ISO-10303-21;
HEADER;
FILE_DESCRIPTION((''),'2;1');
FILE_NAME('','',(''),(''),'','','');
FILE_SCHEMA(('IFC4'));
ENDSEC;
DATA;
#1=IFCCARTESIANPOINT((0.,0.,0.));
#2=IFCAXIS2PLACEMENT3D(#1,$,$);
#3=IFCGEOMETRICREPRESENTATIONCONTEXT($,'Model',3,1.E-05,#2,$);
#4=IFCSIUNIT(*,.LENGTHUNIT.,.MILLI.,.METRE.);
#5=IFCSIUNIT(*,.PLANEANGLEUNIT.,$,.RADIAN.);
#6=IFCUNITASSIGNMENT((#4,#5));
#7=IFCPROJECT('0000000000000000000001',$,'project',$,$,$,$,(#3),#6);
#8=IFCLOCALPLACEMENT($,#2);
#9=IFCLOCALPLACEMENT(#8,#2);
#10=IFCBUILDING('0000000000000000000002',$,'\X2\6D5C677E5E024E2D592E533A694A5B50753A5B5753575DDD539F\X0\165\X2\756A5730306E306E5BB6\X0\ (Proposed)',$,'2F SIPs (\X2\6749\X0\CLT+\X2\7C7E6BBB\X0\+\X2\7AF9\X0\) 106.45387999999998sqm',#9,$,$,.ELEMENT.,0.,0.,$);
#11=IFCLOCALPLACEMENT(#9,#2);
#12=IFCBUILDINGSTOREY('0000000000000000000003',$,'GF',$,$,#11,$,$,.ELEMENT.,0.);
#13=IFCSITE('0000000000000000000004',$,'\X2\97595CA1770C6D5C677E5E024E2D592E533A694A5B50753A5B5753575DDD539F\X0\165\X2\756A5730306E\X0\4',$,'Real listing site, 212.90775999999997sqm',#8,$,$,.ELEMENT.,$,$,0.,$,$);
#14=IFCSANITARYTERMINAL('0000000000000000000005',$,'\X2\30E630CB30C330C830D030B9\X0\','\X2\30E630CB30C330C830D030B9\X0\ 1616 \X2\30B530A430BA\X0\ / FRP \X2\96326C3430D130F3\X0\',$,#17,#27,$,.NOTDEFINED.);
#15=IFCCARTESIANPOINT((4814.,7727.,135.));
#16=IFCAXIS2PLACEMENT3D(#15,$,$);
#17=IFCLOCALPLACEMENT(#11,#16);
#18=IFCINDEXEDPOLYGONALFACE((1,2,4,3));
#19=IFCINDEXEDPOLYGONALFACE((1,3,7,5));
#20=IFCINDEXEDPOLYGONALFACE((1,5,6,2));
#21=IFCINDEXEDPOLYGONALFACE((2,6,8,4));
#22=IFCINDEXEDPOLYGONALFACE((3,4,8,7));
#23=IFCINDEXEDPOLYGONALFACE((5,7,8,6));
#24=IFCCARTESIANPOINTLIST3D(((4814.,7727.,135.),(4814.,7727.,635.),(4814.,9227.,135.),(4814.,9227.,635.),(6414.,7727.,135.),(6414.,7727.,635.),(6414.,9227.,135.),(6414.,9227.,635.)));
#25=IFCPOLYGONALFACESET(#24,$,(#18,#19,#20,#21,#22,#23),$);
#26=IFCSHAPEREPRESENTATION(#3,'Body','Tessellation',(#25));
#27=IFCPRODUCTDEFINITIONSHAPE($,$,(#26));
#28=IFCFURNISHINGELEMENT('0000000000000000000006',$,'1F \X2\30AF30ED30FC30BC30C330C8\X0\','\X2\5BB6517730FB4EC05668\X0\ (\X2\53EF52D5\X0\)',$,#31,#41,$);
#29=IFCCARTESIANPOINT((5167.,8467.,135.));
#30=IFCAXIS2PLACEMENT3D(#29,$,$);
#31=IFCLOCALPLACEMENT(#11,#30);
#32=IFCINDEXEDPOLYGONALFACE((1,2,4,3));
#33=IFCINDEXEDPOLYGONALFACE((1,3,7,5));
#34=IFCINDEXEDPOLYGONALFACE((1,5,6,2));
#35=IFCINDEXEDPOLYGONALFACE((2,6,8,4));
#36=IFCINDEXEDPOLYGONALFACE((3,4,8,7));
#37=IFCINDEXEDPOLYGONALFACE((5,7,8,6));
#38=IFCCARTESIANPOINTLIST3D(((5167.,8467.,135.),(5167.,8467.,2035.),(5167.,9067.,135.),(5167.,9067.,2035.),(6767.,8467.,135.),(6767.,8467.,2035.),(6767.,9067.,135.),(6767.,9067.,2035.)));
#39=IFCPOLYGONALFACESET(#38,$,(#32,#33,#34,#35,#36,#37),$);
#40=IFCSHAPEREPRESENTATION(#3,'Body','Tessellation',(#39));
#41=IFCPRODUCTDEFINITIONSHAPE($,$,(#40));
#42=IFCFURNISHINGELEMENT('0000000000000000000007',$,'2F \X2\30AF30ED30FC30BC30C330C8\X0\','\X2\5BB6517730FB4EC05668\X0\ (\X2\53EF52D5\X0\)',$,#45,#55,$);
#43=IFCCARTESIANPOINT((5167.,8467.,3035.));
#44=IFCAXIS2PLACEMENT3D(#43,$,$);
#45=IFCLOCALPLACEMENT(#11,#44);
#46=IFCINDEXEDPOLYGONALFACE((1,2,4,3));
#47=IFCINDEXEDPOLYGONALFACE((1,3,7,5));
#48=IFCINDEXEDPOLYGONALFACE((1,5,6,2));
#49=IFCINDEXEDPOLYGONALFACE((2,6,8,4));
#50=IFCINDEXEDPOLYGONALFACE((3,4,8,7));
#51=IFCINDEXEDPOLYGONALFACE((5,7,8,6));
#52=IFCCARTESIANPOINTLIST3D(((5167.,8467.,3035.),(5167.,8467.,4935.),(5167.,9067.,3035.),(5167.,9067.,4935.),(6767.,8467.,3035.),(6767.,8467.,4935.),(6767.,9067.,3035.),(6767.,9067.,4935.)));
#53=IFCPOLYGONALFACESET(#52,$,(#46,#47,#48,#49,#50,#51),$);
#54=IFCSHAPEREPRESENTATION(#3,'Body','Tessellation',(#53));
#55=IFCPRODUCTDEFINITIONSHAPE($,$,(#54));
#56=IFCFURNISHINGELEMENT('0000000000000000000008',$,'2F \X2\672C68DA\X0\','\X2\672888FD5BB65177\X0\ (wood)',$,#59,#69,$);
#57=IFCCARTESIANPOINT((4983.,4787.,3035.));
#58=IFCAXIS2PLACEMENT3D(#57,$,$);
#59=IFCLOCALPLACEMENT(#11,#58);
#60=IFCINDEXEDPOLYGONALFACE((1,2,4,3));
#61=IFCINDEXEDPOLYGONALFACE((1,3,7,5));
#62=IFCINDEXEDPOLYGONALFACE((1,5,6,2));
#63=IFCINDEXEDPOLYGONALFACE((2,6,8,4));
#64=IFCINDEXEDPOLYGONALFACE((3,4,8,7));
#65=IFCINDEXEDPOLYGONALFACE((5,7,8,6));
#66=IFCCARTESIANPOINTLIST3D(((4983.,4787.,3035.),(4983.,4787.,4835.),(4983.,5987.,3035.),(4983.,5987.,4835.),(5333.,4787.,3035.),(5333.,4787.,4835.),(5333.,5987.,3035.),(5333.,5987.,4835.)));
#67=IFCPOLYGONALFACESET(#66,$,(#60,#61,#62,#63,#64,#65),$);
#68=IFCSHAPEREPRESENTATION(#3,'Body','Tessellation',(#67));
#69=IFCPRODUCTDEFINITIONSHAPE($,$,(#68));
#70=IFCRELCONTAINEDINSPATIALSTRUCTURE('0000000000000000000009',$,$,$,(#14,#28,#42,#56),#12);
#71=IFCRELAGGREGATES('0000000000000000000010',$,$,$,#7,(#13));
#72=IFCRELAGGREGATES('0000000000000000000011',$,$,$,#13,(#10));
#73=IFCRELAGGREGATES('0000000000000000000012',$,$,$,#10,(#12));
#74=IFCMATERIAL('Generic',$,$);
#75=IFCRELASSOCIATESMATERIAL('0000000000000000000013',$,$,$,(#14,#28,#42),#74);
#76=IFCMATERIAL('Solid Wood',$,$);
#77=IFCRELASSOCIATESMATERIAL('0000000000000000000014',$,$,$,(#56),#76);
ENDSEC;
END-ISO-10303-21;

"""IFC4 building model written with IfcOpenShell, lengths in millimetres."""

from ifc_helpers import new_model, si_unit, frame, frame_2d, origin, place, context, project, spatial, rectangle, extrude, material, element, save


model = new_model("IFC4")

# Units and contexts
model_context = context("Model", 3, precision=1e-05, world=origin())
ifc_project = project(units=[si_unit("LENGTHUNIT", "METRE", prefix="MILLI"), si_unit("PLANEANGLEUNIT", "RADIAN")], contexts=[model_context])

# Site, building, storey
site_placement = place(None, origin())
site = spatial("IfcSite", under=ifc_project, at=site_placement, Name="静岡県浜松市中央区楊子町字南川原165番地の4", ObjectType="Real listing site, 212.90775999999997sqm", CompositionType="ELEMENT", RefElevation=0.0)
building_placement = place(site_placement, origin())
building = spatial("IfcBuilding", under=site, at=building_placement, Name="浜松市中央区楊子町字南川原165番地のの家 (Proposed)", ObjectType="2F SIPs (杉CLT+籾殻+竹) 106.45387999999998sqm", CompositionType="ELEMENT", ElevationOfRefHeight=0.0, ElevationOfTerrain=0.0)
storey_placement = place(building_placement, origin())
storey = spatial("IfcBuildingStorey", under=building, at=storey_placement, Name="GF", CompositionType="ELEMENT", Elevation=0.0)

# Shared definitions
ifc_material_1 = material(Name="Solid Wood")

# Shared definitions
ifc_material_2 = material(Name="Generic")

# Sanitary terminal
sanitary_terminal_placement = place(storey_placement, frame((4814.0, 7727.0, 135.0)))
element("IfcSanitaryTerminal", 1, at=sanitary_terminal_placement, inside=storey, material=ifc_material_2, Name="ユニットバス", Description="ユニットバス 1616 サイズ / FRP 防水パン", PredefinedType="NOTDEFINED", context=model_context, shape_type="SweptSolid", body=[
    extrude(rectangle(XDim=1600.0, YDim=1500.0, at=frame_2d((800.0, 750.0))), frame((4814.0, 7727.0, 135.0)), (0.0, 0.0, 1.0), 500.0),
])

# Furnishing elements
furnishing_1_placement = place(storey_placement, frame((5167.0, 8467.0, 135.0)))
element("IfcFurnishingElement", 2, at=furnishing_1_placement, inside=storey, material=ifc_material_2, Name="1F クローゼット", Description="家具・什器 (可動)", context=model_context, shape_type="SweptSolid", body=[
    extrude(rectangle(XDim=1600.0, YDim=600.0, at=frame_2d((800.0, 300.0))), frame((5167.0, 8467.0, 135.0)), (0.0, 0.0, 1.0), 1900.0),
])
furnishing_2_placement = place(storey_placement, frame((5167.0, 8467.0, 3035.0)))
element("IfcFurnishingElement", 3, at=furnishing_2_placement, inside=storey, material=ifc_material_2, Name="2F クローゼット", Description="家具・什器 (可動)", context=model_context, shape_type="SweptSolid", body=[
    extrude(rectangle(XDim=1600.0, YDim=600.0, at=frame_2d((800.0, 300.0))), frame((5167.0, 8467.0, 3035.0)), (0.0, 0.0, 1.0), 1900.0),
])
furnishing_3_placement = place(storey_placement, frame((4983.0, 4787.0, 3035.0)))
element("IfcFurnishingElement", 4, at=furnishing_3_placement, inside=storey, material=ifc_material_1, Name="2F 本棚", Description="木製家具 (wood)", context=model_context, shape_type="SweptSolid", body=[
    extrude(rectangle(XDim=350.0, YDim=1200.0, at=frame_2d((175.0, 600.0))), frame((4983.0, 4787.0, 3035.0)), (0.0, 0.0, 1.0), 1800.0),
])

save(model, "model.ifc")
